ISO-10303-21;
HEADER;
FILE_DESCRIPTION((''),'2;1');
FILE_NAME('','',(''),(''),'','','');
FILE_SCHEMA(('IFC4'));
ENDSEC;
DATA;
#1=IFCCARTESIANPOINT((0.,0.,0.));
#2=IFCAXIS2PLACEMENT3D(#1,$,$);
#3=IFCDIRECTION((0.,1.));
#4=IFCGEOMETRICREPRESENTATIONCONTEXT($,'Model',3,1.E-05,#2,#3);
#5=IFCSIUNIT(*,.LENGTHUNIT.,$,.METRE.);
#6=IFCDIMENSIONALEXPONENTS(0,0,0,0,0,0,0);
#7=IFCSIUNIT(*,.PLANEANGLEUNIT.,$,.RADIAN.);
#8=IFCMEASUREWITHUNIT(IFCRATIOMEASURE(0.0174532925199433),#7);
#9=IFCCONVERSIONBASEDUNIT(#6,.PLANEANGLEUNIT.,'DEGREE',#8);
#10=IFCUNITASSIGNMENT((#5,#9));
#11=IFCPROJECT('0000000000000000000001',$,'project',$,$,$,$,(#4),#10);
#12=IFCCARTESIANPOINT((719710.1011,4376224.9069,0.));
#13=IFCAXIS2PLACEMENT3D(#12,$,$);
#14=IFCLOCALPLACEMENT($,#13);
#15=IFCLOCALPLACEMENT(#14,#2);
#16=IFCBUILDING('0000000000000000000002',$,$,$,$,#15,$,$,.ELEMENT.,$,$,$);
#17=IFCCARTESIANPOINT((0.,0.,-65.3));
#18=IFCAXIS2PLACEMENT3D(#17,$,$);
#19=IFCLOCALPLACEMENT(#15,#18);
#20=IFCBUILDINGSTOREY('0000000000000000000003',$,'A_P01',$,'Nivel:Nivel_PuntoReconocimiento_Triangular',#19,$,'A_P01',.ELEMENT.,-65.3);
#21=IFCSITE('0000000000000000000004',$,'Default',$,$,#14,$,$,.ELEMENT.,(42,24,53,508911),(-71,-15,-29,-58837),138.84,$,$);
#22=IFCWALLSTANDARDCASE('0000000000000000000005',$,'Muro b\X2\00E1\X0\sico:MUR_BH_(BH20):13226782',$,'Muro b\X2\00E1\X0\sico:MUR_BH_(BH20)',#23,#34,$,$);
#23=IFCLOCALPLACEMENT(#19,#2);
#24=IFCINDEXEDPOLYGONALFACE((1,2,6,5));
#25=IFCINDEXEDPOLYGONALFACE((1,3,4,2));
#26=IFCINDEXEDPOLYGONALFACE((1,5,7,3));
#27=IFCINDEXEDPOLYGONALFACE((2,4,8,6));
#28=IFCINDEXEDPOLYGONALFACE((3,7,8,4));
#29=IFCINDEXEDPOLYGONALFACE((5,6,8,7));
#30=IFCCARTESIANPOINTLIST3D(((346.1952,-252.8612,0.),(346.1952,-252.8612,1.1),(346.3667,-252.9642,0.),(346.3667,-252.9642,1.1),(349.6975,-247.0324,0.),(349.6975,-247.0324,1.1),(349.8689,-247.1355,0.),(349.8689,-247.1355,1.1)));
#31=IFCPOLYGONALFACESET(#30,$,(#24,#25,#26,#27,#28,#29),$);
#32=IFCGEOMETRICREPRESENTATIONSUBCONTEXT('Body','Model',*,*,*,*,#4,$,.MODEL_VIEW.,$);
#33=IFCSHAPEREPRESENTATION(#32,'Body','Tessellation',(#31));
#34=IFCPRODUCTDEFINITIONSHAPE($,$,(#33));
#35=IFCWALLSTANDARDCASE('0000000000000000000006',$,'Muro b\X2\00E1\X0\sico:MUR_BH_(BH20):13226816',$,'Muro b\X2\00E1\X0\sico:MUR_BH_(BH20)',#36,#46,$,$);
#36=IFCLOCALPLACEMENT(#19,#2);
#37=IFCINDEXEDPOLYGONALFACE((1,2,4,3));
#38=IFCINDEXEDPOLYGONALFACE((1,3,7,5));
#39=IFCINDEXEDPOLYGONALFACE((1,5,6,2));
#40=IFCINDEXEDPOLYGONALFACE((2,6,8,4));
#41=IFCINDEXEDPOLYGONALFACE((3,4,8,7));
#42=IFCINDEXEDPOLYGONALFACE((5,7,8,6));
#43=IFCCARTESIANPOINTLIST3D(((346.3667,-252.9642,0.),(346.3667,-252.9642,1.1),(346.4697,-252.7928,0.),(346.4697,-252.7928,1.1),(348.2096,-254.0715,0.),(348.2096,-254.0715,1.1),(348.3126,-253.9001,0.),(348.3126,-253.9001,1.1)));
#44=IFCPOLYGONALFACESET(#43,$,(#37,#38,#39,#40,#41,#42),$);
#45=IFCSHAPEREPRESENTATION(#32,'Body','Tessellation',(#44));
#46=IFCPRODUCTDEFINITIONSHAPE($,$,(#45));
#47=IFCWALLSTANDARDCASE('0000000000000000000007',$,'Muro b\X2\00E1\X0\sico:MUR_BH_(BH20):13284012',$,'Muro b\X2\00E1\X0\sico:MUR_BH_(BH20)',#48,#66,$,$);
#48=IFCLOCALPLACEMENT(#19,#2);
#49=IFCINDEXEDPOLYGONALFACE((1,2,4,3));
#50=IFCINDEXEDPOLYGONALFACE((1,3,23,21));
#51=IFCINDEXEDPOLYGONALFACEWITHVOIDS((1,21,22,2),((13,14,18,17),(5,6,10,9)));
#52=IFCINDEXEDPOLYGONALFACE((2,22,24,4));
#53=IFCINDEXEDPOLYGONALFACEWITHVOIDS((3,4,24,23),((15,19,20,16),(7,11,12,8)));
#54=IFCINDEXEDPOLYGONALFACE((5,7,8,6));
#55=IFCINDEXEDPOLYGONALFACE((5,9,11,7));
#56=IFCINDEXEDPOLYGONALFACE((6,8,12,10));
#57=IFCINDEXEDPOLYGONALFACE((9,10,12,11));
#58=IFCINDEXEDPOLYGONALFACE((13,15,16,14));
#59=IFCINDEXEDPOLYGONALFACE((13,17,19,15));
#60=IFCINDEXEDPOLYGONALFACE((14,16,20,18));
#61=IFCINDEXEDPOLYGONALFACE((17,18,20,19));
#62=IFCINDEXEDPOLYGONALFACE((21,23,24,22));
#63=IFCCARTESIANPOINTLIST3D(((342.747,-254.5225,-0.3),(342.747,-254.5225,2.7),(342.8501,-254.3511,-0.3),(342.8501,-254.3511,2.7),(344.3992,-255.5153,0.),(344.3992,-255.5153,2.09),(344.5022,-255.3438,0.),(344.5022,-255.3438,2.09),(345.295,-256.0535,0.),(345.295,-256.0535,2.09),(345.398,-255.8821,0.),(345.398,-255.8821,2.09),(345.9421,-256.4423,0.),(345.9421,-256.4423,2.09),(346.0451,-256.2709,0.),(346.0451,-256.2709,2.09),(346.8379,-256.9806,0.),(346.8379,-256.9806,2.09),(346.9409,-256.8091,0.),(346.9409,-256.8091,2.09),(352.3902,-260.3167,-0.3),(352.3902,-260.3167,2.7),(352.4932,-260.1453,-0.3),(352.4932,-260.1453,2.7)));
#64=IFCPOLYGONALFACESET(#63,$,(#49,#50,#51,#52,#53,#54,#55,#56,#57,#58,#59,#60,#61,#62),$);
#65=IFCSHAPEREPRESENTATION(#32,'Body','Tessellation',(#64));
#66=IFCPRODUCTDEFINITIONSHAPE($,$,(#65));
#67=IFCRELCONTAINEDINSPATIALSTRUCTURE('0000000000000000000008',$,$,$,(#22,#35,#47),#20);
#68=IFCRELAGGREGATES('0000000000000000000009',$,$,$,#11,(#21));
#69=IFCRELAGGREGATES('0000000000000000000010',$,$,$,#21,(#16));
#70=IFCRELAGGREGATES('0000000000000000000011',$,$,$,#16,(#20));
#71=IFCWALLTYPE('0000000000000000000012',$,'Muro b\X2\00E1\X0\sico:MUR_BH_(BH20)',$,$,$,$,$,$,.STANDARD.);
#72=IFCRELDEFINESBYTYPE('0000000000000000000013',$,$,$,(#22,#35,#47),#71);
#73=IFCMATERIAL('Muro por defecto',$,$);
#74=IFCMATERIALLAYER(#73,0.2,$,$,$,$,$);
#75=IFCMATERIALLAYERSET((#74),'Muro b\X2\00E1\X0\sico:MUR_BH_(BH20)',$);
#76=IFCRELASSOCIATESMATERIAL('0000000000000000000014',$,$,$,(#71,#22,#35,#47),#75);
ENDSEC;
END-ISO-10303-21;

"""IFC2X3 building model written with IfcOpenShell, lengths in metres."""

from ifc_helpers import new_model, entity, si_unit, converted_unit, direction, frame, frame_2d, origin, place, context, subcontext, project, spatial, rectangle, extrude, material, layer, layer_set, layer_usage, type_object, element, save


model = new_model("IFC2X3")

# Units and contexts
model_context = context("Model", 3, precision=1e-05, world=origin(), true_north=direction((0.0, 1.0)))
body_context = subcontext(model_context, "Body", "Model", "MODEL_VIEW")
ifc_project = project(units=[si_unit("LENGTHUNIT", "METRE"), converted_unit("PLANEANGLEUNIT", "DEGREE", entity("IfcRatioMeasure", 0.0174532925199433), si_unit("PLANEANGLEUNIT", "RADIAN"), dimensions=[0, 0, 0, 0, 0, 0, 0])], contexts=[model_context])

# Site, building, storey
site_placement = place(None, frame((719710.1011, 4376224.9069, 0.0)))
site = spatial("IfcSite", under=ifc_project, at=site_placement, Name="Default", CompositionType="ELEMENT", RefLatitude=(42, 24, 53, 508911), RefLongitude=(-71, -15, -29, -58837), RefElevation=138.84)
building_placement = place(site_placement, origin())
building = spatial("IfcBuilding", under=site, at=building_placement, CompositionType="ELEMENT")
storey_placement = place(building_placement, frame((0.0, 0.0, -65.3)))
storey = spatial("IfcBuildingStorey", under=building, at=storey_placement, Name="A_P01", ObjectType="Nivel:Nivel_PuntoReconocimiento_Triangular", LongName="A_P01", CompositionType="ELEMENT", Elevation=-65.3)

# Shared definitions
ifc_material_1 = material(Name="Muro por defecto")
ifc_layer = layer(ifc_material_1, 0.2)
ifc_layer_set = layer_set([ifc_layer], Name="Muro básico:MUR_BH_(BH20)")
wall_type = type_object("IfcWallType", Name="Muro básico:MUR_BH_(BH20)", PredefinedType="STANDARD", material=ifc_layer_set)

# Walls
ifc_layer_usage_1 = layer_usage(ifc_layer_set, "AXIS2", "NEGATIVE", 0.1)
wall_1_placement = place(storey_placement, frame((349.7832, -247.0839, 0.0), z_axis=(0.0, 0.0, 1.0), x_axis=(-0.515038, -0.857167, 0.0)))
element("IfcWallStandardCase", 1, at=wall_1_placement, inside=storey, type_object=wall_type, material=ifc_layer_usage_1, Name="Muro básico:MUR_BH_(BH20):13226782", ObjectType="Muro básico:MUR_BH_(BH20)", context=body_context, shape_type="SweptSolid", body=[
    extrude(rectangle(XDim=6.8, YDim=0.2, at=frame_2d((3.4, 0.0), x_axis=(-1.0, 0.0))), origin(), (0.0, 0.0, 1.0), 1.1),
])
ifc_layer_usage_2 = layer_usage(ifc_layer_set, "AXIS2", "NEGATIVE", 0.1)
wall_2_placement = place(storey_placement, frame((346.4182, -252.8785, 0.0), z_axis=(0.0, 0.0, 1.0), x_axis=(0.857167, -0.515038, 0.0)))
element("IfcWallStandardCase", 2, at=wall_2_placement, inside=storey, type_object=wall_type, material=ifc_layer_usage_2, Name="Muro básico:MUR_BH_(BH20):13226816", ObjectType="Muro básico:MUR_BH_(BH20)", context=body_context, shape_type="SweptSolid", body=[
    extrude(rectangle(XDim=2.15, YDim=0.2, at=frame_2d((1.075, 0.0), x_axis=(-1.0, 0.0))), origin(), (0.0, 0.0, 1.0), 1.1),
])

# Wall, openings
ifc_layer_usage_3 = layer_usage(ifc_layer_set, "AXIS2", "NEGATIVE", 0.1)
wall_3_placement = place(storey_placement, frame((352.4417, -260.231, -0.3), z_axis=(0.0, 0.0, 1.0), x_axis=(-0.857167, 0.515038, 0.0)))
wall_3 = element("IfcWallStandardCase", 3, at=wall_3_placement, inside=storey, type_object=wall_type, material=ifc_layer_usage_3, Name="Muro básico:MUR_BH_(BH20):13284012", ObjectType="Muro básico:MUR_BH_(BH20)", context=body_context, shape_type="SweptSolid", body=[
    extrude(rectangle(XDim=11.25, YDim=0.2, at=frame_2d((5.625, 0.0), x_axis=(-1.0, 0.0))), origin(), (0.0, 0.0, 1.0), 3.0),
])
opening_1_placement = place(wall_3_placement, frame((436.1304, -41.5406, 0.3), z_axis=(0.0, 0.0, 1.0), x_axis=(-0.857167, -0.515038, 0.0)))
element("IfcOpeningElement", 4, at=opening_1_placement, cuts=wall_3, ObjectType="Opening", context=body_context, shape_type="SweptSolid", body=[
    extrude(rectangle(XDim=2.09, YDim=1.045, at=frame_2d((0.0, 0.0), x_axis=(1.0, 0.0))), frame((346.493, -256.54, 1.045), z_axis=(-0.515038, -0.857167, 0.0), x_axis=(0.0, 0.0, -1.0)), (0.0, 0.0, 1.0), 0.2),
])
opening_2_placement = place(wall_3_placement, frame((436.1304, -41.5406, 0.3), z_axis=(0.0, 0.0, 1.0), x_axis=(-0.857167, -0.515038, 0.0)))
element("IfcOpeningElement", 5, at=opening_2_placement, cuts=wall_3, ObjectType="Opening", context=body_context, shape_type="SweptSolid", body=[
    extrude(rectangle(XDim=2.09, YDim=1.045, at=frame_2d((0.0, 0.0), x_axis=(0.0, 1.0))), frame((344.9501, -255.6129, 1.045), z_axis=(-0.515038, -0.857167, 0.0), x_axis=(-0.857167, 0.515038, 0.0)), (0.0, 0.0, 1.0), 0.2),
])

save(model, "model.ifc")
